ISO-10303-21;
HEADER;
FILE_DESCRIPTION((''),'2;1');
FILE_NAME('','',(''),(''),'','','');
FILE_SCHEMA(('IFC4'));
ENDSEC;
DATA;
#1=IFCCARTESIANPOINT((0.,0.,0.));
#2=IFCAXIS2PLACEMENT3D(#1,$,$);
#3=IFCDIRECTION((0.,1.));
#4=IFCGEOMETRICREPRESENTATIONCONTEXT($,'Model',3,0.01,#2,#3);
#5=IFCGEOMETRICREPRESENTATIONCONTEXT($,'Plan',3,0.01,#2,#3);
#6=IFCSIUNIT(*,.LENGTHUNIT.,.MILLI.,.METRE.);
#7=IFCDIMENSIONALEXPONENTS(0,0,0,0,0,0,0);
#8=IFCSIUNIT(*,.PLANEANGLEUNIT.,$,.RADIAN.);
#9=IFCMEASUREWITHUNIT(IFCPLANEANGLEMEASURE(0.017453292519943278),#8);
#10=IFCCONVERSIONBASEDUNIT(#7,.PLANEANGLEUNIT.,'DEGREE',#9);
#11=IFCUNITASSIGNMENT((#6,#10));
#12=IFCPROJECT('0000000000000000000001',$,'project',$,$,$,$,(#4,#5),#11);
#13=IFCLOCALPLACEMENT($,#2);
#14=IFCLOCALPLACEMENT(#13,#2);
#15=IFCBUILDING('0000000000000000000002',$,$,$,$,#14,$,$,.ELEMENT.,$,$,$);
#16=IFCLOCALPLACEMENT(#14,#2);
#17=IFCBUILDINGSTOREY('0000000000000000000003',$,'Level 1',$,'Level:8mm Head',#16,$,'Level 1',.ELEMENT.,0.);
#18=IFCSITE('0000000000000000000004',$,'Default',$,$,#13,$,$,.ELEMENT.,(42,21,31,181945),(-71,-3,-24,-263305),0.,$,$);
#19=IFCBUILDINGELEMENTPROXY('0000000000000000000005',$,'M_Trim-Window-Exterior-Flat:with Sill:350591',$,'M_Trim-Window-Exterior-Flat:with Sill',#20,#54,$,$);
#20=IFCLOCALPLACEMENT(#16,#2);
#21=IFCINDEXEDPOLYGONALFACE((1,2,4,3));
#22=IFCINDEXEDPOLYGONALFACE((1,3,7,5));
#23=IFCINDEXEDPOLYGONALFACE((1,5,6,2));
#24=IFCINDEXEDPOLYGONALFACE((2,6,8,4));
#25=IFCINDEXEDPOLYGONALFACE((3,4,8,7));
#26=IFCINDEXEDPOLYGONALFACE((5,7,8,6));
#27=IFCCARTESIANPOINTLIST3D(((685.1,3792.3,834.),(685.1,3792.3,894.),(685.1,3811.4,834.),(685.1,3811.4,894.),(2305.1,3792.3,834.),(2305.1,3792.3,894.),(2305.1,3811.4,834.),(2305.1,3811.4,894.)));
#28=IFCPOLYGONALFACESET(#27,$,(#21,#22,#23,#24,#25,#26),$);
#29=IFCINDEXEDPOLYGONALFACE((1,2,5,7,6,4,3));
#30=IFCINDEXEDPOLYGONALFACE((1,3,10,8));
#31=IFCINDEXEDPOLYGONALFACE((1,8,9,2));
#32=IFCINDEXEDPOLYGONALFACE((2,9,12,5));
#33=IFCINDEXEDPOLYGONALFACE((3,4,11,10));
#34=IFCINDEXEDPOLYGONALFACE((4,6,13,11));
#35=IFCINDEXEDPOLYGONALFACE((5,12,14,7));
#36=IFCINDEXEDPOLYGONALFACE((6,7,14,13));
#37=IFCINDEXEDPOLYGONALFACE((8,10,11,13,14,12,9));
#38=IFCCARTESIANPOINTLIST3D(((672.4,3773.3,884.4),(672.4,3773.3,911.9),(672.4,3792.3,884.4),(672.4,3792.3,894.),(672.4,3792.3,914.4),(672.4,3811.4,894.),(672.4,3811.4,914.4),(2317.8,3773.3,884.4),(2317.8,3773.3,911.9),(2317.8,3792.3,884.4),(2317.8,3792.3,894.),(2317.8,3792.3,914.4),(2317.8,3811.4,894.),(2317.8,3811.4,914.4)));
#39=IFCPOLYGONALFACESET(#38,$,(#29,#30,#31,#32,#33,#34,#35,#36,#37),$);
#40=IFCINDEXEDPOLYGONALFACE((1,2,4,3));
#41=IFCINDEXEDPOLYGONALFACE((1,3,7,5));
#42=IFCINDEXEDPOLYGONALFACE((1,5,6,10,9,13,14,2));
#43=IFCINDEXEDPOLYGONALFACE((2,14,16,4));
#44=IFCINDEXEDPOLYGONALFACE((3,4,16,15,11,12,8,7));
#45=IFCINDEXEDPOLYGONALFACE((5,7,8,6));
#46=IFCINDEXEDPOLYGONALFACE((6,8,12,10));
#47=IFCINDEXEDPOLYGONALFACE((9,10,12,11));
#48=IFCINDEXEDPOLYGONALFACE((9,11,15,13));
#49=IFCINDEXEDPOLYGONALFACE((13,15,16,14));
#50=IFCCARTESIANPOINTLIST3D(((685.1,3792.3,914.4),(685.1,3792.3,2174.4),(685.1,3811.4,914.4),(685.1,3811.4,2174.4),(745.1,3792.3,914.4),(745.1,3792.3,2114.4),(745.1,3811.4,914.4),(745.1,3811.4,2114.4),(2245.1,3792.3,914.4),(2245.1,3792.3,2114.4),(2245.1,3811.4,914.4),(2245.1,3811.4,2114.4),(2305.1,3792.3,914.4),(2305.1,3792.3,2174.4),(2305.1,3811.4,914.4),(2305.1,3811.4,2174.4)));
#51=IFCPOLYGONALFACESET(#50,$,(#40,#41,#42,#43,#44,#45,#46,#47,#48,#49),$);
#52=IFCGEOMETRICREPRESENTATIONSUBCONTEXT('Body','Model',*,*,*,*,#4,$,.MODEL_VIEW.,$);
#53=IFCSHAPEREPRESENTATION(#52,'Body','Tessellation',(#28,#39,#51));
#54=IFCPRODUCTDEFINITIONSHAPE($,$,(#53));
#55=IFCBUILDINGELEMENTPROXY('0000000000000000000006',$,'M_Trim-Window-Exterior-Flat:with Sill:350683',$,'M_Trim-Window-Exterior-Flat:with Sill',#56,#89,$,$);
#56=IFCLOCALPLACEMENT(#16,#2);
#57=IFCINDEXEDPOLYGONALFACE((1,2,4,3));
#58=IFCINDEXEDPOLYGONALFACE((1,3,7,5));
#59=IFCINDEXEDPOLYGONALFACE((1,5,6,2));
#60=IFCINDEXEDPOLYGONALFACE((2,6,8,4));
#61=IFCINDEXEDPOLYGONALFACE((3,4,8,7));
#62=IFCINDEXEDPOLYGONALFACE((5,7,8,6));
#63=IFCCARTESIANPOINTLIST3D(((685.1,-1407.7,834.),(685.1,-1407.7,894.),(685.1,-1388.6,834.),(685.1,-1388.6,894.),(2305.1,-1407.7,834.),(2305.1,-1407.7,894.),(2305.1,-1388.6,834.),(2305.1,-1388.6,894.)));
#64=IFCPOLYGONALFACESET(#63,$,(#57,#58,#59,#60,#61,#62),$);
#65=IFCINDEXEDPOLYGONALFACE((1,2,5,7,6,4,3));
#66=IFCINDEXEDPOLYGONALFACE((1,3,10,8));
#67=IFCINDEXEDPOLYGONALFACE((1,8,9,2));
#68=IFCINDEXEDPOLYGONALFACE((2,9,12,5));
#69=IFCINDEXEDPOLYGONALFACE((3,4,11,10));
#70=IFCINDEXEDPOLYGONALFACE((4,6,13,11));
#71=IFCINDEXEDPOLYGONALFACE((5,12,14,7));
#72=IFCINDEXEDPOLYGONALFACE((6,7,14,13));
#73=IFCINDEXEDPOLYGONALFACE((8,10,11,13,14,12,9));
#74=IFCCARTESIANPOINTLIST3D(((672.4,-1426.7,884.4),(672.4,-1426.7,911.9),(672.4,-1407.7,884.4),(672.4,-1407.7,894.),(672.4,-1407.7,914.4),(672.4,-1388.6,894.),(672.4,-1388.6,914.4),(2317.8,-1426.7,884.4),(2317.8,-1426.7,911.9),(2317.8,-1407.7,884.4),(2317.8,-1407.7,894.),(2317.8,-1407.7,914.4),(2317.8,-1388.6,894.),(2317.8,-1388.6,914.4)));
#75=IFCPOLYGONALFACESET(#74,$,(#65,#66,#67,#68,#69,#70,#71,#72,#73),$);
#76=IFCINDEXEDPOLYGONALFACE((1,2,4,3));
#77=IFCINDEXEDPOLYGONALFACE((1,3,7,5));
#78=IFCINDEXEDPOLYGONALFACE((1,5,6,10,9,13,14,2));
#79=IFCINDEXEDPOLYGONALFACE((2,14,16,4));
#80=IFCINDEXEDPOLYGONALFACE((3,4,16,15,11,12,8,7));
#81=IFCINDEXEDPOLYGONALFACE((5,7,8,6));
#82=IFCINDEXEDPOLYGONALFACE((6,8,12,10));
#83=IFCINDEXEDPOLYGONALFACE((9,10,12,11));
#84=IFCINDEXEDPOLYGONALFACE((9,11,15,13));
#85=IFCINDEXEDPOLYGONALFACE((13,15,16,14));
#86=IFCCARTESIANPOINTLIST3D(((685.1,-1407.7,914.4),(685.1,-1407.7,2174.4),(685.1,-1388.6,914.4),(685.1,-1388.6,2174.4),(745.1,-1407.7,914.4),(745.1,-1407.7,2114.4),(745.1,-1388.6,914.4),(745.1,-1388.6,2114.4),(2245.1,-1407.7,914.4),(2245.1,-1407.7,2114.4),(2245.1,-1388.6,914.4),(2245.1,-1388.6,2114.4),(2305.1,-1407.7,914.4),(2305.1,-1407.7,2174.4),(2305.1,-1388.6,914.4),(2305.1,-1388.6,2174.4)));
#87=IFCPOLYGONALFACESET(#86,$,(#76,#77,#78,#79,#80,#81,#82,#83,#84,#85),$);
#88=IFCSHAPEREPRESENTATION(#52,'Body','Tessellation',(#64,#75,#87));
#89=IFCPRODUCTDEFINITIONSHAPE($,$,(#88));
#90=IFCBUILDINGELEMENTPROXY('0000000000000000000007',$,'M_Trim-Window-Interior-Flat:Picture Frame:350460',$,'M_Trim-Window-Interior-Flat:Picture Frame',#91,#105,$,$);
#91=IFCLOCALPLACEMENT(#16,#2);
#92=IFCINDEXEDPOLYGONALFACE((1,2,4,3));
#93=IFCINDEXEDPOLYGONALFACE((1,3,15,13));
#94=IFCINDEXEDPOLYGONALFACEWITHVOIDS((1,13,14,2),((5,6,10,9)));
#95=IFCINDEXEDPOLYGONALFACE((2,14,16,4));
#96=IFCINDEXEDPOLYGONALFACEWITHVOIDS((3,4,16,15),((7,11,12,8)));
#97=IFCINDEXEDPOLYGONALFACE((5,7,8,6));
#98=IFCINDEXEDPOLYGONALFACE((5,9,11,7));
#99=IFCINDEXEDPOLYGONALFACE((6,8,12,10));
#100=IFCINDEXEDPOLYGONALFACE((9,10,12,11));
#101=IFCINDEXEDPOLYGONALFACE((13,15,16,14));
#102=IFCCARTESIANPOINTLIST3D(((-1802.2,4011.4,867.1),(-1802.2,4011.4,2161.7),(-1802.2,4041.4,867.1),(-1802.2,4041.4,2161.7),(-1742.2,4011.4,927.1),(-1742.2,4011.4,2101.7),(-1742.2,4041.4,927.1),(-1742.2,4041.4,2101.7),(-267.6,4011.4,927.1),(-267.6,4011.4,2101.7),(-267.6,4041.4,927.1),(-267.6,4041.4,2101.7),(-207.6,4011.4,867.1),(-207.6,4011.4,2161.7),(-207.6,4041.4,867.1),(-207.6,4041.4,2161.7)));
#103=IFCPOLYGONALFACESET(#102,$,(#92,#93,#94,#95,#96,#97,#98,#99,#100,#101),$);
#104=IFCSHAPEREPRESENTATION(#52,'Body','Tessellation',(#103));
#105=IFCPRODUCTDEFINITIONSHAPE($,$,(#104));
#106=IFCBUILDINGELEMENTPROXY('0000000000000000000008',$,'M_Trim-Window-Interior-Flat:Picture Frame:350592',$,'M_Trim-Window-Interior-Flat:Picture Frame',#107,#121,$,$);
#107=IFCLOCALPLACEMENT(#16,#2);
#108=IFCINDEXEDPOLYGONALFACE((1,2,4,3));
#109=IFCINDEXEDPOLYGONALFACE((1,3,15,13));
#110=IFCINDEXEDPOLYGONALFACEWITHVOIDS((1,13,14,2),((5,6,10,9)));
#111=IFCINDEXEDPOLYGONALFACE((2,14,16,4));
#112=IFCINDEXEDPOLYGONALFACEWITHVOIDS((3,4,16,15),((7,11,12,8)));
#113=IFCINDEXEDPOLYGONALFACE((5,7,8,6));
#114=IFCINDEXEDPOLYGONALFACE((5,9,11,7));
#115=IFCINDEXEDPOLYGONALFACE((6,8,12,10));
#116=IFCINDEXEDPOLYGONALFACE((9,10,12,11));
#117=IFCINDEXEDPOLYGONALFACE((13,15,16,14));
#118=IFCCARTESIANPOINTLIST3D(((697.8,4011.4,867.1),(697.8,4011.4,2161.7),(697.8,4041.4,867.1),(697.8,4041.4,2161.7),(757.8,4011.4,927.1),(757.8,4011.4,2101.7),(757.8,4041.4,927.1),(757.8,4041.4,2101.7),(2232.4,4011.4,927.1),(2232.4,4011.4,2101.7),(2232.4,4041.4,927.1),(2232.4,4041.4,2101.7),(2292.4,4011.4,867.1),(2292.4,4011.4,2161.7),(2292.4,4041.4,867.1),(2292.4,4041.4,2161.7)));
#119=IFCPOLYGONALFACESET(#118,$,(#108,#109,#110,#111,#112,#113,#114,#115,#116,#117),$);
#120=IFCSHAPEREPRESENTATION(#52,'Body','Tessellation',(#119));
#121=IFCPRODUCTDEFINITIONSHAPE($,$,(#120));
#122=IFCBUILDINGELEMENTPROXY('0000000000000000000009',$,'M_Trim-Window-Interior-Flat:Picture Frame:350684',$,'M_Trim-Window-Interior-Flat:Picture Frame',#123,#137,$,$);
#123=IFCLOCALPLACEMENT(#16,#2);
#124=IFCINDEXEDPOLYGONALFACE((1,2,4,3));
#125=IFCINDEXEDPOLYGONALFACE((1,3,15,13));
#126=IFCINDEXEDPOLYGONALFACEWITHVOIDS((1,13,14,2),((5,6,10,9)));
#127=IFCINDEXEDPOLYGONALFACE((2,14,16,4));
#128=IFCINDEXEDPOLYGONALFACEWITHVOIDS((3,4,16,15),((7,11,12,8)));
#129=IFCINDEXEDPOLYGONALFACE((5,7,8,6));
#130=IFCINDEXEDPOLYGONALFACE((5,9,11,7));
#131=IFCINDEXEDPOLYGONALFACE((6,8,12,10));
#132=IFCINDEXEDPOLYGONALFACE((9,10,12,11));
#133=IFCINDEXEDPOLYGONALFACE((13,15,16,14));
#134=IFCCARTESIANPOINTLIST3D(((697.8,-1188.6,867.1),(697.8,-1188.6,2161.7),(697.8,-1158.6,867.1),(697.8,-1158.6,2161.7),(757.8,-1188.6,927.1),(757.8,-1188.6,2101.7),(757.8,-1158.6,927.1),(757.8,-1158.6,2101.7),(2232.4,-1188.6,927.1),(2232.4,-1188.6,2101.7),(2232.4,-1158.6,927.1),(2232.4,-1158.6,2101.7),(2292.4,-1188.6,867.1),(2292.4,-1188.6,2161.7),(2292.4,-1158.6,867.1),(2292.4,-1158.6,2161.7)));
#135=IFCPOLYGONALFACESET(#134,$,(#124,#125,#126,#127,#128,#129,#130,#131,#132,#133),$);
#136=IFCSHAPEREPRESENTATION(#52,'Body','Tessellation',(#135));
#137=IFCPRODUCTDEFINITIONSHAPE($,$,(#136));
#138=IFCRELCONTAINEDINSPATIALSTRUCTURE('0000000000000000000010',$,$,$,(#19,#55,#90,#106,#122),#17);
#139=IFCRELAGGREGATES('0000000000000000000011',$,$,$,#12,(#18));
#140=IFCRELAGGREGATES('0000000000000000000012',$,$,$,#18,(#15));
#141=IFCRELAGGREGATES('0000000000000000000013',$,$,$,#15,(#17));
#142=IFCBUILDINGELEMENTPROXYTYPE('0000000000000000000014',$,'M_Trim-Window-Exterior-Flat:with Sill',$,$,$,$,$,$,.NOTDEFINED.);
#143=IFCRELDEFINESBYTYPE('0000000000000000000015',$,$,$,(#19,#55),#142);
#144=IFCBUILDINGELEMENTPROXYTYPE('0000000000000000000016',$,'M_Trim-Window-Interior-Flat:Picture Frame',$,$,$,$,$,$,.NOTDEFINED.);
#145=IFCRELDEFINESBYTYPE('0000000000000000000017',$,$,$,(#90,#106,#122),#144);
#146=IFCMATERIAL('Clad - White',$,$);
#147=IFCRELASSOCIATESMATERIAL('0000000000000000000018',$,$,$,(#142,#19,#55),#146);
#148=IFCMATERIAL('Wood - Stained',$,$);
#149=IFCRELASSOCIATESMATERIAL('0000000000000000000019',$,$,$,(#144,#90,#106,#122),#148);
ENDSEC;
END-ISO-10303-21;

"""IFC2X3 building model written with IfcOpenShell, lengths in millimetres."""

from ifc_helpers import new_model, entity, si_unit, converted_unit, direction, frame, frame_2d, origin, place, context, subcontext, project, spatial, polyline, rectangle, outline, extrude, source, transform, mapped, material, type_object, type_shapes, element, save


model = new_model("IFC2X3")

# Units and contexts
model_context = context("Model", 3, precision=0.01, world=origin(), true_north=direction((0.0, 1.0)))
plan_context = context("Plan", 3, precision=0.01, world=origin(), true_north=direction((0.0, 1.0)))
body_context = subcontext(model_context, "Body", "Model", "MODEL_VIEW")
ifc_project = project(units=[si_unit("LENGTHUNIT", "METRE", prefix="MILLI"), converted_unit("PLANEANGLEUNIT", "DEGREE", entity("IfcPlaneAngleMeasure", 0.017453292519943278), si_unit("PLANEANGLEUNIT", "RADIAN"), dimensions=[0, 0, 0, 0, 0, 0, 0])], contexts=[model_context, plan_context])

# Site, building, storey
site_placement = place(None, origin())
site = spatial("IfcSite", under=ifc_project, at=site_placement, Name="Default", CompositionType="ELEMENT", RefLatitude=(42, 21, 31, 181945), RefLongitude=(-71, -3, -24, -263305), RefElevation=0.0)
building_placement = place(site_placement, origin())
building = spatial("IfcBuilding", under=site, at=building_placement, CompositionType="ELEMENT")
storey_placement = place(building_placement, origin())
storey = spatial("IfcBuildingStorey", under=building, at=storey_placement, Name="Level 1", ObjectType="Level:8mm Head", LongName="Level 1", CompositionType="ELEMENT", Elevation=0.0)

# Shared definitions
ifc_material_1 = material(Name="Wood - Stained")

# Building element proxies
ifc_material_2 = material(Name="Clad - White")
building_element_proxy_type_1 = type_object("IfcBuildingElementProxyType", Name="M_Trim-Window-Exterior-Flat:with Sill", PredefinedType="NOTDEFINED", material=ifc_material_2)
shared_shape_1 = source(origin(), body_context, "Body", "SweptSolid", [
    extrude(rectangle(XDim=1620.0, YDim=60.0, at=frame_2d((0.0, 0.0), x_axis=(1.0, 0.0))), frame((0.0, -1250.4, 0.0), z_axis=(0.0, 0.0, 1.0), x_axis=(-1.0, 0.0, 0.0)), (0.0, 0.0, 1.0), 19.0),
    extrude(outline(polyline([(-19.0, -15.2), (0.0, -15.2), (0.0, -5.7), (19.0, -5.7), (19.0, 14.8), (0.0, 14.8), (-19.0, 12.3), (-19.0, -15.2)])), frame((-822.7, -1214.8, 19.0), z_axis=(1.0, 0.0, 0.0), x_axis=(0.0, 0.0, -1.0)), (0.0, 0.0, 1.0), 1645.4),
    extrude(outline(polyline([(-645.0, -810.0), (615.0, -810.0), (615.0, -750.0), (-585.0, -750.0), (-585.0, 750.0), (615.0, 750.0), (615.0, 810.0), (-645.0, 810.0), (-645.0, -810.0)])), frame((0.0, -585.0, 0.0), z_axis=(0.0, 0.0, 1.0), x_axis=(0.0, -1.0, 0.0)), (0.0, 0.0, 1.0), 19.0),
])
type_shapes(building_element_proxy_type_1, [shared_shape_1])
for number, where, z_axis, x_axis, name in (
    (1, (1495.1, 3811.4, 2114.4), (0.0, -1.0, 0.0), (1.0, 0.0, 0.0), "M_Trim-Window-Exterior-Flat:with Sill:350591"),
    (2, (1495.1, -1388.6, 2114.4), (0.0, -1.0, 0.0), (1.0, 0.0, 0.0), "M_Trim-Window-Exterior-Flat:with Sill:350683"),
):
    element("IfcBuildingElementProxy", number, at=place(storey_placement, frame(where, z_axis=z_axis, x_axis=x_axis)), inside=storey, type_object=building_element_proxy_type_1, material=ifc_material_2, Name=name, ObjectType="M_Trim-Window-Exterior-Flat:with Sill", context=body_context, shape_type="MappedRepresentation", body=[
        mapped(shared_shape_1, transform((0.0, 0.0, 0.0), scale=1.0)),
    ])
building_element_proxy_type_2 = type_object("IfcBuildingElementProxyType", Name="M_Trim-Window-Interior-Flat:Picture Frame", PredefinedType="NOTDEFINED", material=ifc_material_1)
shared_shape_2 = source(origin(), body_context, "Body", "SweptSolid", [
    extrude(outline(polyline([(-797.3, -647.3), (797.3, -647.3), (797.3, 647.3), (-797.3, 647.3), (-797.3, -647.3)]), holes=[polyline([(-737.3, -587.3), (-737.3, 587.3), (737.3, 587.3), (737.3, -587.3), (-737.3, -587.3)])]), frame((0.0, -600.0, 0.0), z_axis=(0.0, 0.0, 1.0), x_axis=(-1.0, 0.0, 0.0)), (0.0, 0.0, 1.0), 30.0),
])
type_shapes(building_element_proxy_type_2, [shared_shape_2])
for number, where, z_axis, x_axis, name in (
    (3, (-1004.9, 4011.4, 2114.4), (0.0, 1.0, 0.0), (-1.0, 0.0, 0.0), "M_Trim-Window-Interior-Flat:Picture Frame:350460"),
    (4, (1495.1, 4011.4, 2114.4), (0.0, 1.0, 0.0), (-1.0, 0.0, 0.0), "M_Trim-Window-Interior-Flat:Picture Frame:350592"),
    (5, (1495.1, -1188.6, 2114.4), (0.0, 1.0, 0.0), (-1.0, 0.0, 0.0), "M_Trim-Window-Interior-Flat:Picture Frame:350684"),
):
    element("IfcBuildingElementProxy", number, at=place(storey_placement, frame(where, z_axis=z_axis, x_axis=x_axis)), inside=storey, type_object=building_element_proxy_type_2, material=ifc_material_1, Name=name, ObjectType="M_Trim-Window-Interior-Flat:Picture Frame", context=body_context, shape_type="MappedRepresentation", body=[
        mapped(shared_shape_2, transform((0.0, 0.0, 0.0), scale=1.0)),
    ])

save(model, "model.ifc")
